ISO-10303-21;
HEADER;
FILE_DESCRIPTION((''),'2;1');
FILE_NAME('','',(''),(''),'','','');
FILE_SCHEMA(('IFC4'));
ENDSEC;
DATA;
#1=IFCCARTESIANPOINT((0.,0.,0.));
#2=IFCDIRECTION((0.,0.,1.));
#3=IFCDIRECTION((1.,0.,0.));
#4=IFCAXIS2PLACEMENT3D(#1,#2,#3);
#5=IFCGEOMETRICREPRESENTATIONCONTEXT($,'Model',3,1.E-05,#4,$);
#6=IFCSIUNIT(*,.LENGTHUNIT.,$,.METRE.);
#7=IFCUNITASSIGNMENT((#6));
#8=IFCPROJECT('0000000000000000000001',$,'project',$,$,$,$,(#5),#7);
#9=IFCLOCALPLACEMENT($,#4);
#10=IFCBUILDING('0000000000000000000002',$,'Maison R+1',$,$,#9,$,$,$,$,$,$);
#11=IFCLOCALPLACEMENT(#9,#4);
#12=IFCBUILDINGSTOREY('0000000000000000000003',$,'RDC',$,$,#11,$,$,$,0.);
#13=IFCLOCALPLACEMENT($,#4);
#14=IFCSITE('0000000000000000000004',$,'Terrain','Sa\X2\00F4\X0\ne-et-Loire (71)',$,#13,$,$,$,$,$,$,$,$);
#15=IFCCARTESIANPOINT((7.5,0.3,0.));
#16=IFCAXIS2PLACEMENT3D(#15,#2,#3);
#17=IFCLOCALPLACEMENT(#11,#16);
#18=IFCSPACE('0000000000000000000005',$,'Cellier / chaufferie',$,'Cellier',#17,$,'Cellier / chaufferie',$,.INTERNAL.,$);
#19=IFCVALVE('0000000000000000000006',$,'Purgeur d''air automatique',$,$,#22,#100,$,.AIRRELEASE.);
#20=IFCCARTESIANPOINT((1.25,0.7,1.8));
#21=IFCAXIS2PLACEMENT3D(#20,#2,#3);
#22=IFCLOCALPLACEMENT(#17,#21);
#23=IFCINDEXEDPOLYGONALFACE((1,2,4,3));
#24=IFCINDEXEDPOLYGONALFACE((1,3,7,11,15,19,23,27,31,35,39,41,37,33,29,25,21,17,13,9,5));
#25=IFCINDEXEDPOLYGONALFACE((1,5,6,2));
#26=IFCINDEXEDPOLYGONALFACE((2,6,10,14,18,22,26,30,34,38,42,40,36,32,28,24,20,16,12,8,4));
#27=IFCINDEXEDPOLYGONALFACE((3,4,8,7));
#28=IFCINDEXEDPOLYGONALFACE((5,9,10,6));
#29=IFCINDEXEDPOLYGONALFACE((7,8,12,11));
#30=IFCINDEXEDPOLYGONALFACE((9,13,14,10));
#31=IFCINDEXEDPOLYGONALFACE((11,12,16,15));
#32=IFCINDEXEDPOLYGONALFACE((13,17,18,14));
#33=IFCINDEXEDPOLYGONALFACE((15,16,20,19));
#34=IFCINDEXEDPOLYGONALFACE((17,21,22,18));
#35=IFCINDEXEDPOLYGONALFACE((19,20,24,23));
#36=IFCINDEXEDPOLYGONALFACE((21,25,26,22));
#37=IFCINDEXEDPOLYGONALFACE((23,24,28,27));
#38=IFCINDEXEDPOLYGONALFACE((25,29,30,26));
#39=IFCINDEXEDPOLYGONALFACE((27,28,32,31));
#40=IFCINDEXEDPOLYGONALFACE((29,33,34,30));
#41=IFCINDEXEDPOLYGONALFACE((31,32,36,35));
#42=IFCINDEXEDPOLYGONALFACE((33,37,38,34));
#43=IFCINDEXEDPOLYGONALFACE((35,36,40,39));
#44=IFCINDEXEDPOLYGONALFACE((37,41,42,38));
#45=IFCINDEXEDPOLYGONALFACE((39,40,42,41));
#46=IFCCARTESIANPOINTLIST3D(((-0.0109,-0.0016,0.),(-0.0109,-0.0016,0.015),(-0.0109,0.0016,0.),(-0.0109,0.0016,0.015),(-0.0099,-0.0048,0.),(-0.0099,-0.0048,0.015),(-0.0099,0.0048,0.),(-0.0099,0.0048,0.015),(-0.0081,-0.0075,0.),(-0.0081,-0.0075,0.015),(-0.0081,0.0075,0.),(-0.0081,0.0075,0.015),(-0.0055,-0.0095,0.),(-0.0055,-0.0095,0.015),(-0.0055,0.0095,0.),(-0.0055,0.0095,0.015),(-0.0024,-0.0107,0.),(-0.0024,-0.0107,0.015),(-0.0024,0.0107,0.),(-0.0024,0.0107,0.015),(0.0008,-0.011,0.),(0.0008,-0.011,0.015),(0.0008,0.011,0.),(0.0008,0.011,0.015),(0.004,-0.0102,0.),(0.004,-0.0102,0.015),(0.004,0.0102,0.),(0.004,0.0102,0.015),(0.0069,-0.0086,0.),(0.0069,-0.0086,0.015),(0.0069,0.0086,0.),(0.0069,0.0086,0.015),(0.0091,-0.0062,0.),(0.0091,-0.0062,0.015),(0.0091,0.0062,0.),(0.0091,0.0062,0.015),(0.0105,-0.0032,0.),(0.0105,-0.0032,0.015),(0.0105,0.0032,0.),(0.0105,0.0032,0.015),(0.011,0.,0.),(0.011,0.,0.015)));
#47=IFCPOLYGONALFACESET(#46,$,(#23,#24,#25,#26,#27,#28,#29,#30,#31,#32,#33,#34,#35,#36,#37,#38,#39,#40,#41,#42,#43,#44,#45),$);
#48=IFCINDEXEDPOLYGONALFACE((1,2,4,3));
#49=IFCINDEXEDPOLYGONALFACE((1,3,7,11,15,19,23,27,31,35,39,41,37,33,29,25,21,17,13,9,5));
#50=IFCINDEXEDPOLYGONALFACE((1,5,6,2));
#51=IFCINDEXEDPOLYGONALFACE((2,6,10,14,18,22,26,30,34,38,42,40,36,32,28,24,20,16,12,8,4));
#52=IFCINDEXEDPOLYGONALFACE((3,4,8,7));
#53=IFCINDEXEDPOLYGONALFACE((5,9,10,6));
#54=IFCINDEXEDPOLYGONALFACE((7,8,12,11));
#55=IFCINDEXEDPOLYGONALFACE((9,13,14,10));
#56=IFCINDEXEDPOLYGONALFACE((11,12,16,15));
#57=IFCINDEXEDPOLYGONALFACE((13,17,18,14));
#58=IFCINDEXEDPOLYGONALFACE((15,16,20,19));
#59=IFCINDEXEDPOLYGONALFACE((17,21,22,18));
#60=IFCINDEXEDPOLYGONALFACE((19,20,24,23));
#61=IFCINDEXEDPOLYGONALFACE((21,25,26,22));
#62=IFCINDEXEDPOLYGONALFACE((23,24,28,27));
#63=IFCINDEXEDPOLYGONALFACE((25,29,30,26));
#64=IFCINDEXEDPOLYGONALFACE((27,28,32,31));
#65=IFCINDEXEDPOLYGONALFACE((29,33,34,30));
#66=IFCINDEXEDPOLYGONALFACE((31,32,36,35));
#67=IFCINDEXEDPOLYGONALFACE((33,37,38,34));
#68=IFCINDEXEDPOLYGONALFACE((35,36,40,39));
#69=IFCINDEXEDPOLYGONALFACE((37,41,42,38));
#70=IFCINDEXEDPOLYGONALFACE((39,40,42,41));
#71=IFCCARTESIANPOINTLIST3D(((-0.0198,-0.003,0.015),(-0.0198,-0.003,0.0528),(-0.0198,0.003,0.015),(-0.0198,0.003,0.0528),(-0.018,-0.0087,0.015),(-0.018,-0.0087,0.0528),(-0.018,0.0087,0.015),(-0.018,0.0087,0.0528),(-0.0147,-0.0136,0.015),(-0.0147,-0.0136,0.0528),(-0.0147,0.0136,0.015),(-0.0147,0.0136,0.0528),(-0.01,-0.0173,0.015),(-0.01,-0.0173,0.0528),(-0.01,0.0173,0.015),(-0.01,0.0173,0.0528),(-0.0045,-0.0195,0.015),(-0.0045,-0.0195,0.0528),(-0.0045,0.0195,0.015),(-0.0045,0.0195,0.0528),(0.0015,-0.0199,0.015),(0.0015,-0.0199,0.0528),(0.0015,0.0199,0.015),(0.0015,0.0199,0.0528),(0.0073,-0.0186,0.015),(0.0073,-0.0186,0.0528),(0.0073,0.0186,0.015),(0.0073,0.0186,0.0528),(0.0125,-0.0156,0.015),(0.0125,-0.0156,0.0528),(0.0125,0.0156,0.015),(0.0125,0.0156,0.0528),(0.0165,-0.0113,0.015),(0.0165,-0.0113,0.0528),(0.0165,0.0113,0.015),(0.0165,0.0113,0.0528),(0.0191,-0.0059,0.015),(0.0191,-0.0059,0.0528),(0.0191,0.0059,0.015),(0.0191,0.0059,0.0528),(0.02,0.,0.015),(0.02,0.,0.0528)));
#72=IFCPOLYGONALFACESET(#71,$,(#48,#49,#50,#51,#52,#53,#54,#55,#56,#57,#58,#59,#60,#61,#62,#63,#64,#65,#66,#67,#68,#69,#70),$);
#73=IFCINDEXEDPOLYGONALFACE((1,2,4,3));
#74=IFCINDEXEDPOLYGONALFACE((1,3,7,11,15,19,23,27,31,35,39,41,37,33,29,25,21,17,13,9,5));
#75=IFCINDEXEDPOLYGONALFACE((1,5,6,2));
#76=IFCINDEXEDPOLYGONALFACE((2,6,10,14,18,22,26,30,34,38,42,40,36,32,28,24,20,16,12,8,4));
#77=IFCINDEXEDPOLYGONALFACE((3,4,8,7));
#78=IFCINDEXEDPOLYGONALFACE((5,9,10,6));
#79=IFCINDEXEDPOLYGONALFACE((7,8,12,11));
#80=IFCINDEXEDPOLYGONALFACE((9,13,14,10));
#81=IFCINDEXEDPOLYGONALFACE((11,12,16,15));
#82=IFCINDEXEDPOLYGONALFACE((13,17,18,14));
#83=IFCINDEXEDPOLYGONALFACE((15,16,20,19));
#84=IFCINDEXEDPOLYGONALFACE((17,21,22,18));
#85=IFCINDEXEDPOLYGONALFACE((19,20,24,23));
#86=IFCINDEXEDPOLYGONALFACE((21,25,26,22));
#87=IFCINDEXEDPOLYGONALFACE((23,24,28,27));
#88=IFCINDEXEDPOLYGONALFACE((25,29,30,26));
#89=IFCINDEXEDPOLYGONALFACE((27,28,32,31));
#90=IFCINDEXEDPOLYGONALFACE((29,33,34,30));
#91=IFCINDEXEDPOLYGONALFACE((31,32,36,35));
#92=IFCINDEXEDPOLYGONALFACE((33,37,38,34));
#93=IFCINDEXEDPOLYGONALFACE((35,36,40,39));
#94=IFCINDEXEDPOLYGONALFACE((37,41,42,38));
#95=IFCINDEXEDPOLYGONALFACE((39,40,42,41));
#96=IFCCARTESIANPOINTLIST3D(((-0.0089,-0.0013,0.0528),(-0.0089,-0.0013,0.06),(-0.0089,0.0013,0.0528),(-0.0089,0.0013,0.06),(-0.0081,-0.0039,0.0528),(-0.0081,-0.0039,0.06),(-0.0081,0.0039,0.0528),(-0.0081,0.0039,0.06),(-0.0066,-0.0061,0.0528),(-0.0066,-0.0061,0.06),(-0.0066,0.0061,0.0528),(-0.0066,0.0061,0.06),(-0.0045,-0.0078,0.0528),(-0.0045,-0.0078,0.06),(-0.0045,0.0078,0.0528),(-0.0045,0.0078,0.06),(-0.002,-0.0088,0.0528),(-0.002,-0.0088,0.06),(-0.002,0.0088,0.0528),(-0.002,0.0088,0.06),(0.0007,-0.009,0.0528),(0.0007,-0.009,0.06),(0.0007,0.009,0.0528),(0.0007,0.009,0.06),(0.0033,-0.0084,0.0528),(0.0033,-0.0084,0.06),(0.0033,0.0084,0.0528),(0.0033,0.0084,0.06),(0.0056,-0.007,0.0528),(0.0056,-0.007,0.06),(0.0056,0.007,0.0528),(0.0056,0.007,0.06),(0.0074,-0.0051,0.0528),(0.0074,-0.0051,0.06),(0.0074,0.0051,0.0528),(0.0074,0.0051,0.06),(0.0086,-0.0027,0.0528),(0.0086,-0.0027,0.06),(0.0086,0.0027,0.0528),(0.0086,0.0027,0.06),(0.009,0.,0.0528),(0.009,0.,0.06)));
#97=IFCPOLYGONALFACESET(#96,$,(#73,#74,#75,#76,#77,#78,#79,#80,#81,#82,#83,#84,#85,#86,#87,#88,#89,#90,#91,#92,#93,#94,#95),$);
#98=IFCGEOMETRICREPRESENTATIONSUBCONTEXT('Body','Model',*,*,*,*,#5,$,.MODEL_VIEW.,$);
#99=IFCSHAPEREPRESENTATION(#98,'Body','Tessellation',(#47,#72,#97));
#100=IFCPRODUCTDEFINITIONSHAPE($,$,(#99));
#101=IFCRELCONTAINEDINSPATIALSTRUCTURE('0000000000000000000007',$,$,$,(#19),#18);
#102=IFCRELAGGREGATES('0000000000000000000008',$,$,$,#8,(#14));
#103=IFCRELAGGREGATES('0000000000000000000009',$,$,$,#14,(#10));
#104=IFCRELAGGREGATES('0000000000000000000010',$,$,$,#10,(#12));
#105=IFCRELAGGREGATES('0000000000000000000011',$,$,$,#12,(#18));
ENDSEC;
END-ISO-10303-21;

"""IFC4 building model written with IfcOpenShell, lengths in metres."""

from ifc_helpers import new_model, si_unit, frame, origin_with_axes, place, context, subcontext, project, spatial, circle, extrude, element, save


model = new_model("IFC4")

# Units and contexts
model_context = context("Model", 3, precision=1e-05, world=origin_with_axes())
body_context = subcontext(model_context, "Body", "Model", "MODEL_VIEW")
ifc_project = project(units=[si_unit("LENGTHUNIT", "METRE")], contexts=[model_context])

# Site, building, storey
site_placement = place(None, origin_with_axes())
site = spatial("IfcSite", under=ifc_project, at=site_placement, Name="Terrain", Description="Saône-et-Loire (71)")
building_placement = place(None, origin_with_axes())
building = spatial("IfcBuilding", under=site, at=building_placement, Name="Maison R+1")
storey_placement = place(building_placement, origin_with_axes())
storey = spatial("IfcBuildingStorey", under=building, at=storey_placement, Name="RDC", Elevation=0.0)

# Shared definitions
space_placement = place(storey_placement, frame((7.5, 0.3, 0.0), z_axis=(0.0, 0.0, 1.0), x_axis=(1.0, 0.0, 0.0)))
space = spatial("IfcSpace", under=storey, at=space_placement, Name="Cellier / chaufferie", ObjectType="Cellier", LongName="Cellier / chaufferie", PredefinedType="INTERNAL")

# Valve
valve_1_placement = place(space_placement, frame((1.25, 0.7, 1.8), z_axis=(0.0, 0.0, 1.0), x_axis=(1.0, 0.0, 0.0)))
element("IfcValve", 1, at=valve_1_placement, inside=space, Name="Purgeur d'air automatique", PredefinedType="AIRRELEASE", context=body_context, shape_type="SweptSolid", body=[
    extrude(circle(Radius=0.011), origin_with_axes(), (0.0, 0.0, 1.0), 0.015),
    extrude(circle(Radius=0.02), frame((0.0, 0.0, 0.015), z_axis=(0.0, 0.0, 1.0), x_axis=(1.0, 0.0, 0.0)), (0.0, 0.0, 1.0), 0.0378),
    extrude(circle(Radius=0.009), frame((0.0, 0.0, 0.0528), z_axis=(0.0, 0.0, 1.0), x_axis=(1.0, 0.0, 0.0)), (0.0, 0.0, 1.0), 0.0072),
])

save(model, "model.ifc")
